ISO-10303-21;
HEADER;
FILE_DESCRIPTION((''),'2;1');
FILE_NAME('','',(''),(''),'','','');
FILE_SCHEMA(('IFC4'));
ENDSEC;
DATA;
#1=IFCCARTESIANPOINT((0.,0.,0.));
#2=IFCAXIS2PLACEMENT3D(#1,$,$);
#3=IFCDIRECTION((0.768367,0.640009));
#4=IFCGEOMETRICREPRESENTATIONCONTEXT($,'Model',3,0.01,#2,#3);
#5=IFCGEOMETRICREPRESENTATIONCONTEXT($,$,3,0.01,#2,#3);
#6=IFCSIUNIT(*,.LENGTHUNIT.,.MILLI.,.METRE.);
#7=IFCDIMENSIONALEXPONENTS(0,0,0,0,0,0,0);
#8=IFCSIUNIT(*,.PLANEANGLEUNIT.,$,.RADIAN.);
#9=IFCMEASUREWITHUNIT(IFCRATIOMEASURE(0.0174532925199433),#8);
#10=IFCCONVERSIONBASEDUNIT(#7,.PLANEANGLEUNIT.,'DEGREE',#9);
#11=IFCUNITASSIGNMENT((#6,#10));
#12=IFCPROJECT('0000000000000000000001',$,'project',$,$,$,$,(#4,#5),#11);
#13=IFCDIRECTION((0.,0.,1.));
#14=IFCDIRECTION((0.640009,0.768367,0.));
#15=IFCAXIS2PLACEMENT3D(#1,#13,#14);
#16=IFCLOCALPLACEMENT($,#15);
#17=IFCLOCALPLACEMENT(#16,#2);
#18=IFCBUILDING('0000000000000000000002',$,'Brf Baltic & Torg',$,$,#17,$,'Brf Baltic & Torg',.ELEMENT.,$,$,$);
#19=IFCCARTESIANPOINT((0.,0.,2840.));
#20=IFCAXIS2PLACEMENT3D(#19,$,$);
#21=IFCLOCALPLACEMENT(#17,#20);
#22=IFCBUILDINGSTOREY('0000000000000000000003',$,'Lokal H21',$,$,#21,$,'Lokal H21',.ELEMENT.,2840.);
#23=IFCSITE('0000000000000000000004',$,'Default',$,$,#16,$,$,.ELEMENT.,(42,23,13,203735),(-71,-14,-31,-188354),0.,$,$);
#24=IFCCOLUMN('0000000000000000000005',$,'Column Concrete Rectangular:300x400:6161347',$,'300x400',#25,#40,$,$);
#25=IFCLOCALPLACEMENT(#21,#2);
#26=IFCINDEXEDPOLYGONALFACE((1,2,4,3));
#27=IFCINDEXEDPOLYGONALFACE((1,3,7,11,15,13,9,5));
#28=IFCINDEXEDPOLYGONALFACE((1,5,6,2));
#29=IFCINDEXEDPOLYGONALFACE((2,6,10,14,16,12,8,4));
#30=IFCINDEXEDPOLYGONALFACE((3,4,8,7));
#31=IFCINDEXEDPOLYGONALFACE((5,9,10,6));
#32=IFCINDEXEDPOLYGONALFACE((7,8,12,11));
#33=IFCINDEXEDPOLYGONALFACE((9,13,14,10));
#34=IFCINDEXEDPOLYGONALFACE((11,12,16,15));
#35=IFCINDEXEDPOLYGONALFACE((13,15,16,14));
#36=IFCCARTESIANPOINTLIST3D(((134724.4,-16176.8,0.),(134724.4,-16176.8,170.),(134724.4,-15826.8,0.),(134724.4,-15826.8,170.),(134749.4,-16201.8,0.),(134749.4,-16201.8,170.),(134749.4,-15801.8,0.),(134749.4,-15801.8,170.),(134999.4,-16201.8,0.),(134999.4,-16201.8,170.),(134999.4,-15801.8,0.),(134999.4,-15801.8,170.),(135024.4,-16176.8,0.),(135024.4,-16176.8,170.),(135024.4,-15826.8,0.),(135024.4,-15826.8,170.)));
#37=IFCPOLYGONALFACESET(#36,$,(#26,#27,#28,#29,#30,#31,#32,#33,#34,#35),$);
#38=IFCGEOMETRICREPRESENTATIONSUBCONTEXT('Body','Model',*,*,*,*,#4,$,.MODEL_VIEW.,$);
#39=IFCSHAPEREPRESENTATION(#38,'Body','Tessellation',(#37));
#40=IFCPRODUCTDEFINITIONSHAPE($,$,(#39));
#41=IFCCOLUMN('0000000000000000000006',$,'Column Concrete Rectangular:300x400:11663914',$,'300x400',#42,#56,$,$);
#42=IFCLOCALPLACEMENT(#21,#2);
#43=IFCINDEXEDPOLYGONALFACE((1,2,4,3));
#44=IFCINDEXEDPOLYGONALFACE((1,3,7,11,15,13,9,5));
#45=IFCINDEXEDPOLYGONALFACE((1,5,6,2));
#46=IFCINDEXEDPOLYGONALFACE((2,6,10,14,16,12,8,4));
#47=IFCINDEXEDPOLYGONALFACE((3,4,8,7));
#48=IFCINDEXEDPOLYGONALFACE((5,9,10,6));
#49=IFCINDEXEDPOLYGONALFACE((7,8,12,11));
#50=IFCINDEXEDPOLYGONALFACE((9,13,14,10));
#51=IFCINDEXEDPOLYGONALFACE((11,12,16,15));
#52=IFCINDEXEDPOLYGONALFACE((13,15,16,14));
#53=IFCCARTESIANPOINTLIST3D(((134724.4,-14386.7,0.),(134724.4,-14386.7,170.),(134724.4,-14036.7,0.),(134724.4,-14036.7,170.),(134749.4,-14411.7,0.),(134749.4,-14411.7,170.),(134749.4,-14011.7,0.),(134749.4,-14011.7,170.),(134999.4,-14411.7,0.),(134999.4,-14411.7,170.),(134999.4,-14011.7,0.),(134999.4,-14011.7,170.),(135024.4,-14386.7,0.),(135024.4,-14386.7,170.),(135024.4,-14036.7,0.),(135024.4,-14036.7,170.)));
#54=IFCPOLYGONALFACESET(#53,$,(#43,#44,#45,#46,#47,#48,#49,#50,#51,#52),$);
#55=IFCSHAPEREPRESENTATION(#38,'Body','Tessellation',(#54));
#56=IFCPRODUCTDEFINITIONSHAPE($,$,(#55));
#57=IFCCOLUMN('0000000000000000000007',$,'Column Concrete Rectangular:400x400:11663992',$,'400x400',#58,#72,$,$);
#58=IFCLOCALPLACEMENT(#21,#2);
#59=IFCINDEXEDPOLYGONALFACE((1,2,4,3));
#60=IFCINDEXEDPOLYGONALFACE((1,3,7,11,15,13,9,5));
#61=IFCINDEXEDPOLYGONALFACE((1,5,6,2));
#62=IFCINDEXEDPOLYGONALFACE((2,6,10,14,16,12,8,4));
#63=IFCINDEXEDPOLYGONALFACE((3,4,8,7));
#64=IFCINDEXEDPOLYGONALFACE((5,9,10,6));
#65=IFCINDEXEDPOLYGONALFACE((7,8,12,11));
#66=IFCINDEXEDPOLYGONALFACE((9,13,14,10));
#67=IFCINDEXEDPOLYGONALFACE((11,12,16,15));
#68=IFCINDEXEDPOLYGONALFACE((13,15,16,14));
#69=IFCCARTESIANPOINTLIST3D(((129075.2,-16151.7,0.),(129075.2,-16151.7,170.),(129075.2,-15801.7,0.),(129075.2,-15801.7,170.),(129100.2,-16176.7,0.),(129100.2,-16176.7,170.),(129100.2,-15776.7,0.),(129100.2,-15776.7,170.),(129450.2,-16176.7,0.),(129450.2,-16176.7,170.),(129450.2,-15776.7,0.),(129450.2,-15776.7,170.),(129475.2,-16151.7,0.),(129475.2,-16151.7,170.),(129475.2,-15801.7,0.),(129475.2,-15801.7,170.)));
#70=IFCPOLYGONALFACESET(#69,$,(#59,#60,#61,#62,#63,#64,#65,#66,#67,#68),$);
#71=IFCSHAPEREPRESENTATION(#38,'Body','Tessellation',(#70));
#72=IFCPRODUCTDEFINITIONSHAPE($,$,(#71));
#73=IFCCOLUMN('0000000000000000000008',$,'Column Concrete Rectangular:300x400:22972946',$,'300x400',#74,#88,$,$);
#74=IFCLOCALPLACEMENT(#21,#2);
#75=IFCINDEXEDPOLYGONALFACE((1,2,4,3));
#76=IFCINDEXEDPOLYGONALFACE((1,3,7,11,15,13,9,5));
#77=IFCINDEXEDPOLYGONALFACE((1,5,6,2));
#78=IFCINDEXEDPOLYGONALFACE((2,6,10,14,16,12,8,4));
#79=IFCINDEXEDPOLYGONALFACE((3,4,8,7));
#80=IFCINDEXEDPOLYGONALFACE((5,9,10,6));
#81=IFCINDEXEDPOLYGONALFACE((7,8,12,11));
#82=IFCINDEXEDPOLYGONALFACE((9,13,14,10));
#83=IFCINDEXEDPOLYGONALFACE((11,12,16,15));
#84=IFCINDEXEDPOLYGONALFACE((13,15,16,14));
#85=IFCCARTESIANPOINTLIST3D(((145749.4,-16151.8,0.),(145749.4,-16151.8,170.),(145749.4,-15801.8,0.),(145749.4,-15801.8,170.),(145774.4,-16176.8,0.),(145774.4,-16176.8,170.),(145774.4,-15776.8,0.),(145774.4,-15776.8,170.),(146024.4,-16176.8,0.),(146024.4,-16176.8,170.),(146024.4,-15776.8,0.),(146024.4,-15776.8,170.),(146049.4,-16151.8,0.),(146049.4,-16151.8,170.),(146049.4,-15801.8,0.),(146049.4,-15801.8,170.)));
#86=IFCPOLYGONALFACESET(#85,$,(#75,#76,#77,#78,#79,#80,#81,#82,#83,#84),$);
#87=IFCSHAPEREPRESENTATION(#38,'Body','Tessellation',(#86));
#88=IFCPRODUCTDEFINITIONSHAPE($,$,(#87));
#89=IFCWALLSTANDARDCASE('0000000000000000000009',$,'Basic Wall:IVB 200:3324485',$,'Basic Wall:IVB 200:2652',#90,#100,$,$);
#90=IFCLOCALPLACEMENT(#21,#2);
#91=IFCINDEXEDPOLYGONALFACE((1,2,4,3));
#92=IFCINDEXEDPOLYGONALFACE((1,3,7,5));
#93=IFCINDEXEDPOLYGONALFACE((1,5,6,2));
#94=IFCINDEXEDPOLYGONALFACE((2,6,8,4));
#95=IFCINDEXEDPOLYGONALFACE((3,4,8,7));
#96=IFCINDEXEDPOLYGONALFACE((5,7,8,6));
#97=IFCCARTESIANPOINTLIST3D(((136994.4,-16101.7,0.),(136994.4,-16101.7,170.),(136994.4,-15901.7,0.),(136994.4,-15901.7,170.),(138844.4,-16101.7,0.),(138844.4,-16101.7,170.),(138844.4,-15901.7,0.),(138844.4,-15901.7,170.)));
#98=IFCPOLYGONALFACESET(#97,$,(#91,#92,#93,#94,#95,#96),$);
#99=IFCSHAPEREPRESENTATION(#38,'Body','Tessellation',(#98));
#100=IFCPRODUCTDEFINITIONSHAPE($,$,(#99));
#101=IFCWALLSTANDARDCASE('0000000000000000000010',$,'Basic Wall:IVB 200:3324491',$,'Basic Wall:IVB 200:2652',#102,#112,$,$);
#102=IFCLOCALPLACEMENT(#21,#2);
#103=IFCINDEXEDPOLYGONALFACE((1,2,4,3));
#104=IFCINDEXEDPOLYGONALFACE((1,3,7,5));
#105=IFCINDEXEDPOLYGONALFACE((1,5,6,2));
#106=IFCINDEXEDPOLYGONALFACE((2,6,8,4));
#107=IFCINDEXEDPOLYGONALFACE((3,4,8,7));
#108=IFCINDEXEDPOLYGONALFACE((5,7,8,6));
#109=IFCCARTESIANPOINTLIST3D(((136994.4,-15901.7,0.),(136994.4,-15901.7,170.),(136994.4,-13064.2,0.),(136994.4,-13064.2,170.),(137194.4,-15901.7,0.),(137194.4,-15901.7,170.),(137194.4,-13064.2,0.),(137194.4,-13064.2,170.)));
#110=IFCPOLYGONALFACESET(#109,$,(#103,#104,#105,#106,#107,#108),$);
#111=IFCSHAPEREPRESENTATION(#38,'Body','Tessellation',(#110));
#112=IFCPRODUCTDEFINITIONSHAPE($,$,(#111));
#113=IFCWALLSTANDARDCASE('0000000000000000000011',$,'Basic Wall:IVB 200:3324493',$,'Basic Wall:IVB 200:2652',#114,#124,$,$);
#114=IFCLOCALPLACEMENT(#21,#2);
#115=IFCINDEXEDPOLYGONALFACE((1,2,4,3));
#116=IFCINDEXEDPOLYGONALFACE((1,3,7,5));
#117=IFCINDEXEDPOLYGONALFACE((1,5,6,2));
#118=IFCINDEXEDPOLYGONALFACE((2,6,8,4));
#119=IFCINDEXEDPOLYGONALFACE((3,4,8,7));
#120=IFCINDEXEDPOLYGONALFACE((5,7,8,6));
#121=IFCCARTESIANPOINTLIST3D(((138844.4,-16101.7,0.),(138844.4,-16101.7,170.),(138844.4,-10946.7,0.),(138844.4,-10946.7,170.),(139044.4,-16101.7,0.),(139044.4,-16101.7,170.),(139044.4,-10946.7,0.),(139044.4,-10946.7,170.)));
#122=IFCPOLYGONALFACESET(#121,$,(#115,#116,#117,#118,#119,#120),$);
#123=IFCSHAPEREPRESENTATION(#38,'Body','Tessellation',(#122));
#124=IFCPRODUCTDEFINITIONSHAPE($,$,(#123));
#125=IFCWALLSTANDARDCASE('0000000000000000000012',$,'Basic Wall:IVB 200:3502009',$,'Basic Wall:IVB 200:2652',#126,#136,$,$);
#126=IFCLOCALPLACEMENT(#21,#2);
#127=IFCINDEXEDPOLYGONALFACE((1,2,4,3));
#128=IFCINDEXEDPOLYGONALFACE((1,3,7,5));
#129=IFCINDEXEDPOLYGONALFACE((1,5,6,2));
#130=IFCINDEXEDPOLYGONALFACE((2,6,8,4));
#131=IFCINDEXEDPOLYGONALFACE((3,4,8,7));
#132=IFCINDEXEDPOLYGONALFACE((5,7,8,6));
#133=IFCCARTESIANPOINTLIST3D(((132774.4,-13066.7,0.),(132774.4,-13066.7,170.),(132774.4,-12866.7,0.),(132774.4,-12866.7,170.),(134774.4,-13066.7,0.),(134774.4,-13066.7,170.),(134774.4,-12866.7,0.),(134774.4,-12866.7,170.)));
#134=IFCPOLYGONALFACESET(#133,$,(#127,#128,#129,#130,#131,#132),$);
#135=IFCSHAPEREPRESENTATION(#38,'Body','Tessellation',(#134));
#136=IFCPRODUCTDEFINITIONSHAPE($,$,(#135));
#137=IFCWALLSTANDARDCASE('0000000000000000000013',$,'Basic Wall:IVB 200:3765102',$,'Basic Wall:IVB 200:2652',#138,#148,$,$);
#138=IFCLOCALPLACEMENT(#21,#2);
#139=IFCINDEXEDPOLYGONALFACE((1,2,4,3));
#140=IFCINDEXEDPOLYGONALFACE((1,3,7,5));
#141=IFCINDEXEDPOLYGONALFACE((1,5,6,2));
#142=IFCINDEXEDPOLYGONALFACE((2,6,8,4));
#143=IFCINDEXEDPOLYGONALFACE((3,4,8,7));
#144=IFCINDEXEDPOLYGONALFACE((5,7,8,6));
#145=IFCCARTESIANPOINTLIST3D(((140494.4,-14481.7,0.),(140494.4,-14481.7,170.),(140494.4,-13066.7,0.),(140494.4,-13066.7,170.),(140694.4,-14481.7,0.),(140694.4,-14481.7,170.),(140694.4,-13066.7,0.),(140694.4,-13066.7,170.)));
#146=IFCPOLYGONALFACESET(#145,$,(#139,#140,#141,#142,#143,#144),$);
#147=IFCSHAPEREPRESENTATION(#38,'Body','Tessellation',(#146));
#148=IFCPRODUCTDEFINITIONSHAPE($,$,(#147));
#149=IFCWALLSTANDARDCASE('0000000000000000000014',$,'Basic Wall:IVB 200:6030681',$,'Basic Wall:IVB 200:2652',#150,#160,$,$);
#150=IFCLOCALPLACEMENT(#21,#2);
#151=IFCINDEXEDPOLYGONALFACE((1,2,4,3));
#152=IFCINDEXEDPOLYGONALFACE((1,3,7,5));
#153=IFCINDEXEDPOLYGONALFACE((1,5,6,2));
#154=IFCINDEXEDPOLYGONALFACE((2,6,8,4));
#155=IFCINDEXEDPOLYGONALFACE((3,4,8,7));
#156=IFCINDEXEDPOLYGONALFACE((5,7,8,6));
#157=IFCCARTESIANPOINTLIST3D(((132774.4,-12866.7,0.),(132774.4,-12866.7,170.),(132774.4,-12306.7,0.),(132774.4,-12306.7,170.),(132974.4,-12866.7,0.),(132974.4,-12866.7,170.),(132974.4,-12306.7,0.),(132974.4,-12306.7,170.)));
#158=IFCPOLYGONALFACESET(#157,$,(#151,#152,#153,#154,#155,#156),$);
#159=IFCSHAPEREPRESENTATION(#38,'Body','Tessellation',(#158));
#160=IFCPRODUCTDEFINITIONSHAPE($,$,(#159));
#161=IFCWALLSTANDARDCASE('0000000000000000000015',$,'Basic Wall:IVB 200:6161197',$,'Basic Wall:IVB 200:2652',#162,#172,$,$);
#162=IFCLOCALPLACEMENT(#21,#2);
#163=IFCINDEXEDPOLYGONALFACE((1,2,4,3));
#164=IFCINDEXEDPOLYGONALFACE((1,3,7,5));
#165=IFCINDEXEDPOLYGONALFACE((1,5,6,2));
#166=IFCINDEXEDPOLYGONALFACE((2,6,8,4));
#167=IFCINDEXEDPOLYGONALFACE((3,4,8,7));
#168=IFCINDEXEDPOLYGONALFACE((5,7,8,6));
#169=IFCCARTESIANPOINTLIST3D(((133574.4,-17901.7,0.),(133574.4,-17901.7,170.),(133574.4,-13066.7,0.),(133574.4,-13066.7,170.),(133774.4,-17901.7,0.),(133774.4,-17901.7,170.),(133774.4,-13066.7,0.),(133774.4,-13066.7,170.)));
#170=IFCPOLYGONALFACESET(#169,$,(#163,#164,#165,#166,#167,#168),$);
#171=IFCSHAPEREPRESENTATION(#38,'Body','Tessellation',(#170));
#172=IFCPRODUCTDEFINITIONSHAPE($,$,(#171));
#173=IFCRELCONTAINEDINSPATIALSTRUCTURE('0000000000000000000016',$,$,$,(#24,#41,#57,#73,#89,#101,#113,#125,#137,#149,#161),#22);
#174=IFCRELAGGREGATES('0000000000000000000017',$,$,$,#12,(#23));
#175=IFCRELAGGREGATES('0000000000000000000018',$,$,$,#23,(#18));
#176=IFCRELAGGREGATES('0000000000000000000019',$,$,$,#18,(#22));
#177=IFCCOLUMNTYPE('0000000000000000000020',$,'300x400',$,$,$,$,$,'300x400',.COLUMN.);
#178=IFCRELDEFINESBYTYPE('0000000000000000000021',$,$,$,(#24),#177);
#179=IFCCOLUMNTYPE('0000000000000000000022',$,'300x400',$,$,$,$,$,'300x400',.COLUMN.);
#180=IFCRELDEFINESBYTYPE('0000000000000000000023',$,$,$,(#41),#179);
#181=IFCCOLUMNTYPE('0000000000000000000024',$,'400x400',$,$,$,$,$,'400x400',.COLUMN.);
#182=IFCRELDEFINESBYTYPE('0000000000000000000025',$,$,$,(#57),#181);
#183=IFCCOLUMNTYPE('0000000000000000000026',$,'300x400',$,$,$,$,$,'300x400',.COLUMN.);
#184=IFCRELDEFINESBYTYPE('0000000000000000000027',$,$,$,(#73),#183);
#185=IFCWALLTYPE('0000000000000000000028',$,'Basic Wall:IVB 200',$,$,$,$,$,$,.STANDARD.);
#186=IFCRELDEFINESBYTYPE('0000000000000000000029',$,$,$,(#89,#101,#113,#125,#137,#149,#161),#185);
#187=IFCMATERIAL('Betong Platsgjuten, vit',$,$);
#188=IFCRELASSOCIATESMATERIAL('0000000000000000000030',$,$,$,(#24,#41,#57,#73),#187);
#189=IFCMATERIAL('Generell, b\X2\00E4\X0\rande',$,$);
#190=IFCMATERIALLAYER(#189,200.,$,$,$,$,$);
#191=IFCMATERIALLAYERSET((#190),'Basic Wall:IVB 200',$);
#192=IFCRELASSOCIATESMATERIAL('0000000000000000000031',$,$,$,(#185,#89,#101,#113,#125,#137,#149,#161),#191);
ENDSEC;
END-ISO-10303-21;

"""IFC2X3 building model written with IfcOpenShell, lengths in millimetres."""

from ifc_helpers import new_model, entity, si_unit, converted_unit, direction, frame, frame_2d, origin, place, context, subcontext, project, spatial, polyline, rectangle, outline, extrude, clip, halfspace, source, transform, mapped, material, layer, layer_set, layer_usage, type_object, type_shapes, element, save


model = new_model("IFC2X3")

# Units and contexts
model_context = context("Model", 3, precision=0.01, world=origin(), true_north=direction((0.768367, 0.640009)))
context_of_model = context(None, 3, precision=0.01, world=origin(), true_north=direction((0.768367, 0.640009)))
body_context = subcontext(model_context, "Body", "Model", "MODEL_VIEW")
ifc_project = project(units=[si_unit("LENGTHUNIT", "METRE", prefix="MILLI"), converted_unit("PLANEANGLEUNIT", "DEGREE", entity("IfcRatioMeasure", 0.0174532925199433), si_unit("PLANEANGLEUNIT", "RADIAN"), dimensions=[0, 0, 0, 0, 0, 0, 0])], contexts=[model_context, context_of_model])

# Site, building, storey
site_placement = place(None, frame((0.0, 0.0, 0.0), z_axis=(0.0, 0.0, 1.0), x_axis=(0.640009, 0.768367, 0.0)))
site = spatial("IfcSite", under=ifc_project, at=site_placement, Name="Default", CompositionType="ELEMENT", RefLatitude=(42, 23, 13, 203735), RefLongitude=(-71, -14, -31, -188354), RefElevation=0.0)
building_placement = place(site_placement, origin())
building = spatial("IfcBuilding", under=site, at=building_placement, Name="Brf Baltic & Torg", LongName="Brf Baltic & Torg", CompositionType="ELEMENT")
storey_placement = place(building_placement, frame((0.0, 0.0, 2840.0)))
storey = spatial("IfcBuildingStorey", under=building, at=storey_placement, Name="Lokal H21", LongName="Lokal H21", CompositionType="ELEMENT", Elevation=2840.0)

# Columns
ifc_material_1 = material(Name="Betong Platsgjuten, vit")
column_type_1 = type_object("IfcColumnType", Name="300x400", ElementType="300x400", PredefinedType="COLUMN")
shared_shape_1 = source(origin(), body_context, "Body", "SweptSolid", [
    extrude(outline(polyline([(-175.0, -150.0), (175.0, -150.0), (200.0, -125.0), (200.0, 125.0), (175.0, 150.0), (-175.0, 150.0), (-200.0, 125.0), (-200.0, -125.0), (-175.0, -150.0)])), frame((0.0, 0.0, 2840.0), z_axis=(0.0, 0.0, 1.0), x_axis=(0.0, -1.0, 0.0)), (0.0, 0.0, 1.0), 170.0),
])
type_shapes(column_type_1, [shared_shape_1])
column_1_placement = place(storey_placement, frame((134874.4, -16001.8, -2840.0)))
element("IfcColumn", 1, at=column_1_placement, inside=storey, type_object=column_type_1, material=ifc_material_1, Name="Column Concrete Rectangular:300x400:6161347", ObjectType="300x400", context=body_context, shape_type="MappedRepresentation", body=[
    mapped(shared_shape_1, transform((0.0, 0.0, 0.0), scale=1.0)),
])
column_type_2 = type_object("IfcColumnType", Name="300x400", ElementType="300x400", PredefinedType="COLUMN")
shared_shape_2 = source(origin(), body_context, "Body", "SweptSolid", [
    extrude(outline(polyline([(-175.0, -150.0), (175.0, -150.0), (200.0, -125.0), (200.0, 125.0), (175.0, 150.0), (-175.0, 150.0), (-200.0, 125.0), (-200.0, -125.0), (-175.0, -150.0)])), frame((0.0, 0.0, 2840.0), z_axis=(0.0, 0.0, 1.0), x_axis=(0.0, -1.0, 0.0)), (0.0, 0.0, 1.0), 170.0),
])
type_shapes(column_type_2, [shared_shape_2])
column_2_placement = place(storey_placement, frame((134874.4, -14211.7, -2840.0)))
element("IfcColumn", 2, at=column_2_placement, inside=storey, type_object=column_type_2, material=ifc_material_1, Name="Column Concrete Rectangular:300x400:11663914", ObjectType="300x400", context=body_context, shape_type="MappedRepresentation", body=[
    mapped(shared_shape_2, transform((0.0, 0.0, 0.0), scale=1.0)),
])
column_type_3 = type_object("IfcColumnType", Name="400x400", ElementType="400x400", PredefinedType="COLUMN")
shared_shape_3 = source(origin(), body_context, "Body", "SweptSolid", [
    extrude(outline(polyline([(-175.0, -200.0), (175.0, -200.0), (200.0, -175.0), (200.0, 175.0), (175.0, 200.0), (-175.0, 200.0), (-200.0, 175.0), (-200.0, -175.0), (-175.0, -200.0)])), frame((0.0, 0.0, 2840.0), z_axis=(0.0, 0.0, 1.0), x_axis=(0.0, -1.0, 0.0)), (0.0, 0.0, 1.0), 170.0),
])
type_shapes(column_type_3, [shared_shape_3])
column_3_placement = place(storey_placement, frame((129275.2, -15976.7, -2840.0)))
element("IfcColumn", 3, at=column_3_placement, inside=storey, type_object=column_type_3, material=ifc_material_1, Name="Column Concrete Rectangular:400x400:11663992", ObjectType="400x400", context=body_context, shape_type="MappedRepresentation", body=[
    mapped(shared_shape_3, transform((0.0, 0.0, 0.0), scale=1.0)),
])
column_type_4 = type_object("IfcColumnType", Name="300x400", ElementType="300x400", PredefinedType="COLUMN")
shared_shape_4 = source(origin(), body_context, "Body", "SweptSolid", [
    extrude(outline(polyline([(-175.0, -150.0), (175.0, -150.0), (200.0, -125.0), (200.0, 125.0), (175.0, 150.0), (-175.0, 150.0), (-200.0, 125.0), (-200.0, -125.0), (-175.0, -150.0)])), frame((0.0, 0.0, 2840.0), z_axis=(0.0, 0.0, 1.0), x_axis=(0.0, -1.0, 0.0)), (0.0, 0.0, 1.0), 170.0),
])
type_shapes(column_type_4, [shared_shape_4])
column_4_placement = place(storey_placement, frame((145899.4, -15976.8, -2840.0)))
element("IfcColumn", 4, at=column_4_placement, inside=storey, type_object=column_type_4, material=ifc_material_1, Name="Column Concrete Rectangular:300x400:22972946", ObjectType="300x400", context=body_context, shape_type="MappedRepresentation", body=[
    mapped(shared_shape_4, transform((0.0, 0.0, 0.0), scale=1.0)),
])

# Wall
ifc_material_2 = material(Name="Generell, bärande")
ifc_layer_1 = layer(ifc_material_2, 200.0)
ifc_layer_set_1 = layer_set([ifc_layer_1], Name="Basic Wall:IVB 200")
ifc_layer_usage_1 = layer_usage(ifc_layer_set_1, "AXIS2", "NEGATIVE", 100.0)
wall_type_1 = type_object("IfcWallType", Name="Basic Wall:IVB 200", PredefinedType="STANDARD", material=ifc_layer_set_1)
wall_1_placement = place(storey_placement, frame((138844.4, -16001.7, 0.0), z_axis=(0.0, 0.0, 1.0), x_axis=(-1.0, 0.0, 0.0)))
element("IfcWallStandardCase", 5, at=wall_1_placement, inside=storey, type_object=wall_type_1, material=ifc_layer_usage_1, Name="Basic Wall:IVB 200:3324485", ObjectType="Basic Wall:IVB 200:2652", context=body_context, shape_type="Clipping", body=[
    clip(extrude(rectangle(XDim=1850.0, YDim=200.0, at=frame_2d((925.0, 0.0), x_axis=(-1.0, 0.0))), origin(), (0.0, 0.0, 1.0), 170.0), halfspace(frame((0.0, 0.0, -1190.0)), True)),
])

# Walls
ifc_layer_usage_2 = layer_usage(ifc_layer_set_1, "AXIS2", "NEGATIVE", 100.0)
wall_2_placement = place(storey_placement, frame((137094.4, -15901.7, 0.0), z_axis=(0.0, 0.0, 1.0), x_axis=(0.0, 1.0, 0.0)))
element("IfcWallStandardCase", 6, at=wall_2_placement, inside=storey, type_object=wall_type_1, material=ifc_layer_usage_2, Name="Basic Wall:IVB 200:3324491", ObjectType="Basic Wall:IVB 200:2652", context=body_context, shape_type="Clipping", body=[
    clip(extrude(rectangle(XDim=2837.5, YDim=200.0, at=frame_2d((1418.8, 0.0), x_axis=(-1.0, 0.0))), origin(), (0.0, 0.0, 1.0), 170.0), halfspace(frame((0.0, 0.0, -1190.0)), True)),
])
ifc_layer_usage_3 = layer_usage(ifc_layer_set_1, "AXIS2", "NEGATIVE", 100.0)
wall_3_placement = place(storey_placement, frame((138944.4, -10946.7, 0.0), z_axis=(0.0, 0.0, 1.0), x_axis=(0.0, -1.0, 0.0)))
element("IfcWallStandardCase", 7, at=wall_3_placement, inside=storey, type_object=wall_type_1, material=ifc_layer_usage_3, Name="Basic Wall:IVB 200:3324493", ObjectType="Basic Wall:IVB 200:2652", context=body_context, shape_type="Clipping", body=[
    clip(extrude(rectangle(XDim=5155.0, YDim=200.0, at=frame_2d((2577.5, 0.0), x_axis=(-1.0, 0.0))), origin(), (0.0, 0.0, 1.0), 170.0), halfspace(frame((0.0, 0.0, -1190.0)), True)),
])
ifc_layer_usage_4 = layer_usage(ifc_layer_set_1, "AXIS2", "NEGATIVE", 100.0)
wall_4_placement = place(storey_placement, frame((134774.4, -12966.7, 0.0), z_axis=(0.0, 0.0, 1.0), x_axis=(-1.0, 0.0, 0.0)))
element("IfcWallStandardCase", 8, at=wall_4_placement, inside=storey, type_object=wall_type_1, material=ifc_layer_usage_4, Name="Basic Wall:IVB 200:3502009", ObjectType="Basic Wall:IVB 200:2652", context=body_context, shape_type="Clipping", body=[
    clip(extrude(rectangle(XDim=2000.0, YDim=200.0, at=frame_2d((1000.0, 0.0), x_axis=(-1.0, 0.0))), origin(), (0.0, 0.0, 1.0), 170.0), halfspace(frame((0.0, 0.0, -1190.0)), True)),
])
ifc_layer_usage_5 = layer_usage(ifc_layer_set_1, "AXIS2", "NEGATIVE", 100.0)
wall_5_placement = place(storey_placement, frame((140594.4, -13066.7, 0.0), z_axis=(0.0, 0.0, 1.0), x_axis=(0.0, -1.0, 0.0)))
element("IfcWallStandardCase", 9, at=wall_5_placement, inside=storey, type_object=wall_type_1, material=ifc_layer_usage_5, Name="Basic Wall:IVB 200:3765102", ObjectType="Basic Wall:IVB 200:2652", context=body_context, shape_type="Clipping", body=[
    clip(extrude(rectangle(XDim=1415.0, YDim=200.0, at=frame_2d((707.5, 0.0), x_axis=(-1.0, 0.0))), origin(), (0.0, 0.0, 1.0), 170.0), halfspace(frame((0.0, 0.0, -1190.0)), True)),
])

# Walls
ifc_layer_usage_6 = layer_usage(ifc_layer_set_1, "AXIS2", "POSITIVE", -100.0)
wall_6_placement = place(storey_placement, frame((132874.4, -12866.7, 0.0), z_axis=(0.0, 0.0, 1.0), x_axis=(0.0, 1.0, 0.0)))
element("IfcWallStandardCase", 10, at=wall_6_placement, inside=storey, type_object=wall_type_1, material=ifc_layer_usage_6, Name="Basic Wall:IVB 200:6030681", ObjectType="Basic Wall:IVB 200:2652", context=body_context, shape_type="Clipping", body=[
    clip(extrude(rectangle(XDim=560.0, YDim=200.0, at=frame_2d((280.0, 0.0), x_axis=(-1.0, 0.0))), origin(), (0.0, 0.0, 1.0), 170.0), halfspace(frame((0.0, 0.0, -1190.0)), True)),
])
ifc_layer_usage_7 = layer_usage(ifc_layer_set_1, "AXIS2", "NEGATIVE", 100.0)
wall_7_placement = place(storey_placement, frame((133674.4, -17901.7, 0.0), z_axis=(0.0, 0.0, 1.0), x_axis=(0.0, 1.0, 0.0)))
element("IfcWallStandardCase", 11, at=wall_7_placement, inside=storey, type_object=wall_type_1, material=ifc_layer_usage_7, Name="Basic Wall:IVB 200:6161197", ObjectType="Basic Wall:IVB 200:2652", context=body_context, shape_type="Clipping", body=[
    clip(extrude(rectangle(XDim=4835.0, YDim=200.0, at=frame_2d((2417.5, 0.0), x_axis=(-1.0, 0.0))), origin(), (0.0, 0.0, 1.0), 170.0), halfspace(frame((0.0, 0.0, -1190.0)), True)),
])

save(model, "model.ifc")
